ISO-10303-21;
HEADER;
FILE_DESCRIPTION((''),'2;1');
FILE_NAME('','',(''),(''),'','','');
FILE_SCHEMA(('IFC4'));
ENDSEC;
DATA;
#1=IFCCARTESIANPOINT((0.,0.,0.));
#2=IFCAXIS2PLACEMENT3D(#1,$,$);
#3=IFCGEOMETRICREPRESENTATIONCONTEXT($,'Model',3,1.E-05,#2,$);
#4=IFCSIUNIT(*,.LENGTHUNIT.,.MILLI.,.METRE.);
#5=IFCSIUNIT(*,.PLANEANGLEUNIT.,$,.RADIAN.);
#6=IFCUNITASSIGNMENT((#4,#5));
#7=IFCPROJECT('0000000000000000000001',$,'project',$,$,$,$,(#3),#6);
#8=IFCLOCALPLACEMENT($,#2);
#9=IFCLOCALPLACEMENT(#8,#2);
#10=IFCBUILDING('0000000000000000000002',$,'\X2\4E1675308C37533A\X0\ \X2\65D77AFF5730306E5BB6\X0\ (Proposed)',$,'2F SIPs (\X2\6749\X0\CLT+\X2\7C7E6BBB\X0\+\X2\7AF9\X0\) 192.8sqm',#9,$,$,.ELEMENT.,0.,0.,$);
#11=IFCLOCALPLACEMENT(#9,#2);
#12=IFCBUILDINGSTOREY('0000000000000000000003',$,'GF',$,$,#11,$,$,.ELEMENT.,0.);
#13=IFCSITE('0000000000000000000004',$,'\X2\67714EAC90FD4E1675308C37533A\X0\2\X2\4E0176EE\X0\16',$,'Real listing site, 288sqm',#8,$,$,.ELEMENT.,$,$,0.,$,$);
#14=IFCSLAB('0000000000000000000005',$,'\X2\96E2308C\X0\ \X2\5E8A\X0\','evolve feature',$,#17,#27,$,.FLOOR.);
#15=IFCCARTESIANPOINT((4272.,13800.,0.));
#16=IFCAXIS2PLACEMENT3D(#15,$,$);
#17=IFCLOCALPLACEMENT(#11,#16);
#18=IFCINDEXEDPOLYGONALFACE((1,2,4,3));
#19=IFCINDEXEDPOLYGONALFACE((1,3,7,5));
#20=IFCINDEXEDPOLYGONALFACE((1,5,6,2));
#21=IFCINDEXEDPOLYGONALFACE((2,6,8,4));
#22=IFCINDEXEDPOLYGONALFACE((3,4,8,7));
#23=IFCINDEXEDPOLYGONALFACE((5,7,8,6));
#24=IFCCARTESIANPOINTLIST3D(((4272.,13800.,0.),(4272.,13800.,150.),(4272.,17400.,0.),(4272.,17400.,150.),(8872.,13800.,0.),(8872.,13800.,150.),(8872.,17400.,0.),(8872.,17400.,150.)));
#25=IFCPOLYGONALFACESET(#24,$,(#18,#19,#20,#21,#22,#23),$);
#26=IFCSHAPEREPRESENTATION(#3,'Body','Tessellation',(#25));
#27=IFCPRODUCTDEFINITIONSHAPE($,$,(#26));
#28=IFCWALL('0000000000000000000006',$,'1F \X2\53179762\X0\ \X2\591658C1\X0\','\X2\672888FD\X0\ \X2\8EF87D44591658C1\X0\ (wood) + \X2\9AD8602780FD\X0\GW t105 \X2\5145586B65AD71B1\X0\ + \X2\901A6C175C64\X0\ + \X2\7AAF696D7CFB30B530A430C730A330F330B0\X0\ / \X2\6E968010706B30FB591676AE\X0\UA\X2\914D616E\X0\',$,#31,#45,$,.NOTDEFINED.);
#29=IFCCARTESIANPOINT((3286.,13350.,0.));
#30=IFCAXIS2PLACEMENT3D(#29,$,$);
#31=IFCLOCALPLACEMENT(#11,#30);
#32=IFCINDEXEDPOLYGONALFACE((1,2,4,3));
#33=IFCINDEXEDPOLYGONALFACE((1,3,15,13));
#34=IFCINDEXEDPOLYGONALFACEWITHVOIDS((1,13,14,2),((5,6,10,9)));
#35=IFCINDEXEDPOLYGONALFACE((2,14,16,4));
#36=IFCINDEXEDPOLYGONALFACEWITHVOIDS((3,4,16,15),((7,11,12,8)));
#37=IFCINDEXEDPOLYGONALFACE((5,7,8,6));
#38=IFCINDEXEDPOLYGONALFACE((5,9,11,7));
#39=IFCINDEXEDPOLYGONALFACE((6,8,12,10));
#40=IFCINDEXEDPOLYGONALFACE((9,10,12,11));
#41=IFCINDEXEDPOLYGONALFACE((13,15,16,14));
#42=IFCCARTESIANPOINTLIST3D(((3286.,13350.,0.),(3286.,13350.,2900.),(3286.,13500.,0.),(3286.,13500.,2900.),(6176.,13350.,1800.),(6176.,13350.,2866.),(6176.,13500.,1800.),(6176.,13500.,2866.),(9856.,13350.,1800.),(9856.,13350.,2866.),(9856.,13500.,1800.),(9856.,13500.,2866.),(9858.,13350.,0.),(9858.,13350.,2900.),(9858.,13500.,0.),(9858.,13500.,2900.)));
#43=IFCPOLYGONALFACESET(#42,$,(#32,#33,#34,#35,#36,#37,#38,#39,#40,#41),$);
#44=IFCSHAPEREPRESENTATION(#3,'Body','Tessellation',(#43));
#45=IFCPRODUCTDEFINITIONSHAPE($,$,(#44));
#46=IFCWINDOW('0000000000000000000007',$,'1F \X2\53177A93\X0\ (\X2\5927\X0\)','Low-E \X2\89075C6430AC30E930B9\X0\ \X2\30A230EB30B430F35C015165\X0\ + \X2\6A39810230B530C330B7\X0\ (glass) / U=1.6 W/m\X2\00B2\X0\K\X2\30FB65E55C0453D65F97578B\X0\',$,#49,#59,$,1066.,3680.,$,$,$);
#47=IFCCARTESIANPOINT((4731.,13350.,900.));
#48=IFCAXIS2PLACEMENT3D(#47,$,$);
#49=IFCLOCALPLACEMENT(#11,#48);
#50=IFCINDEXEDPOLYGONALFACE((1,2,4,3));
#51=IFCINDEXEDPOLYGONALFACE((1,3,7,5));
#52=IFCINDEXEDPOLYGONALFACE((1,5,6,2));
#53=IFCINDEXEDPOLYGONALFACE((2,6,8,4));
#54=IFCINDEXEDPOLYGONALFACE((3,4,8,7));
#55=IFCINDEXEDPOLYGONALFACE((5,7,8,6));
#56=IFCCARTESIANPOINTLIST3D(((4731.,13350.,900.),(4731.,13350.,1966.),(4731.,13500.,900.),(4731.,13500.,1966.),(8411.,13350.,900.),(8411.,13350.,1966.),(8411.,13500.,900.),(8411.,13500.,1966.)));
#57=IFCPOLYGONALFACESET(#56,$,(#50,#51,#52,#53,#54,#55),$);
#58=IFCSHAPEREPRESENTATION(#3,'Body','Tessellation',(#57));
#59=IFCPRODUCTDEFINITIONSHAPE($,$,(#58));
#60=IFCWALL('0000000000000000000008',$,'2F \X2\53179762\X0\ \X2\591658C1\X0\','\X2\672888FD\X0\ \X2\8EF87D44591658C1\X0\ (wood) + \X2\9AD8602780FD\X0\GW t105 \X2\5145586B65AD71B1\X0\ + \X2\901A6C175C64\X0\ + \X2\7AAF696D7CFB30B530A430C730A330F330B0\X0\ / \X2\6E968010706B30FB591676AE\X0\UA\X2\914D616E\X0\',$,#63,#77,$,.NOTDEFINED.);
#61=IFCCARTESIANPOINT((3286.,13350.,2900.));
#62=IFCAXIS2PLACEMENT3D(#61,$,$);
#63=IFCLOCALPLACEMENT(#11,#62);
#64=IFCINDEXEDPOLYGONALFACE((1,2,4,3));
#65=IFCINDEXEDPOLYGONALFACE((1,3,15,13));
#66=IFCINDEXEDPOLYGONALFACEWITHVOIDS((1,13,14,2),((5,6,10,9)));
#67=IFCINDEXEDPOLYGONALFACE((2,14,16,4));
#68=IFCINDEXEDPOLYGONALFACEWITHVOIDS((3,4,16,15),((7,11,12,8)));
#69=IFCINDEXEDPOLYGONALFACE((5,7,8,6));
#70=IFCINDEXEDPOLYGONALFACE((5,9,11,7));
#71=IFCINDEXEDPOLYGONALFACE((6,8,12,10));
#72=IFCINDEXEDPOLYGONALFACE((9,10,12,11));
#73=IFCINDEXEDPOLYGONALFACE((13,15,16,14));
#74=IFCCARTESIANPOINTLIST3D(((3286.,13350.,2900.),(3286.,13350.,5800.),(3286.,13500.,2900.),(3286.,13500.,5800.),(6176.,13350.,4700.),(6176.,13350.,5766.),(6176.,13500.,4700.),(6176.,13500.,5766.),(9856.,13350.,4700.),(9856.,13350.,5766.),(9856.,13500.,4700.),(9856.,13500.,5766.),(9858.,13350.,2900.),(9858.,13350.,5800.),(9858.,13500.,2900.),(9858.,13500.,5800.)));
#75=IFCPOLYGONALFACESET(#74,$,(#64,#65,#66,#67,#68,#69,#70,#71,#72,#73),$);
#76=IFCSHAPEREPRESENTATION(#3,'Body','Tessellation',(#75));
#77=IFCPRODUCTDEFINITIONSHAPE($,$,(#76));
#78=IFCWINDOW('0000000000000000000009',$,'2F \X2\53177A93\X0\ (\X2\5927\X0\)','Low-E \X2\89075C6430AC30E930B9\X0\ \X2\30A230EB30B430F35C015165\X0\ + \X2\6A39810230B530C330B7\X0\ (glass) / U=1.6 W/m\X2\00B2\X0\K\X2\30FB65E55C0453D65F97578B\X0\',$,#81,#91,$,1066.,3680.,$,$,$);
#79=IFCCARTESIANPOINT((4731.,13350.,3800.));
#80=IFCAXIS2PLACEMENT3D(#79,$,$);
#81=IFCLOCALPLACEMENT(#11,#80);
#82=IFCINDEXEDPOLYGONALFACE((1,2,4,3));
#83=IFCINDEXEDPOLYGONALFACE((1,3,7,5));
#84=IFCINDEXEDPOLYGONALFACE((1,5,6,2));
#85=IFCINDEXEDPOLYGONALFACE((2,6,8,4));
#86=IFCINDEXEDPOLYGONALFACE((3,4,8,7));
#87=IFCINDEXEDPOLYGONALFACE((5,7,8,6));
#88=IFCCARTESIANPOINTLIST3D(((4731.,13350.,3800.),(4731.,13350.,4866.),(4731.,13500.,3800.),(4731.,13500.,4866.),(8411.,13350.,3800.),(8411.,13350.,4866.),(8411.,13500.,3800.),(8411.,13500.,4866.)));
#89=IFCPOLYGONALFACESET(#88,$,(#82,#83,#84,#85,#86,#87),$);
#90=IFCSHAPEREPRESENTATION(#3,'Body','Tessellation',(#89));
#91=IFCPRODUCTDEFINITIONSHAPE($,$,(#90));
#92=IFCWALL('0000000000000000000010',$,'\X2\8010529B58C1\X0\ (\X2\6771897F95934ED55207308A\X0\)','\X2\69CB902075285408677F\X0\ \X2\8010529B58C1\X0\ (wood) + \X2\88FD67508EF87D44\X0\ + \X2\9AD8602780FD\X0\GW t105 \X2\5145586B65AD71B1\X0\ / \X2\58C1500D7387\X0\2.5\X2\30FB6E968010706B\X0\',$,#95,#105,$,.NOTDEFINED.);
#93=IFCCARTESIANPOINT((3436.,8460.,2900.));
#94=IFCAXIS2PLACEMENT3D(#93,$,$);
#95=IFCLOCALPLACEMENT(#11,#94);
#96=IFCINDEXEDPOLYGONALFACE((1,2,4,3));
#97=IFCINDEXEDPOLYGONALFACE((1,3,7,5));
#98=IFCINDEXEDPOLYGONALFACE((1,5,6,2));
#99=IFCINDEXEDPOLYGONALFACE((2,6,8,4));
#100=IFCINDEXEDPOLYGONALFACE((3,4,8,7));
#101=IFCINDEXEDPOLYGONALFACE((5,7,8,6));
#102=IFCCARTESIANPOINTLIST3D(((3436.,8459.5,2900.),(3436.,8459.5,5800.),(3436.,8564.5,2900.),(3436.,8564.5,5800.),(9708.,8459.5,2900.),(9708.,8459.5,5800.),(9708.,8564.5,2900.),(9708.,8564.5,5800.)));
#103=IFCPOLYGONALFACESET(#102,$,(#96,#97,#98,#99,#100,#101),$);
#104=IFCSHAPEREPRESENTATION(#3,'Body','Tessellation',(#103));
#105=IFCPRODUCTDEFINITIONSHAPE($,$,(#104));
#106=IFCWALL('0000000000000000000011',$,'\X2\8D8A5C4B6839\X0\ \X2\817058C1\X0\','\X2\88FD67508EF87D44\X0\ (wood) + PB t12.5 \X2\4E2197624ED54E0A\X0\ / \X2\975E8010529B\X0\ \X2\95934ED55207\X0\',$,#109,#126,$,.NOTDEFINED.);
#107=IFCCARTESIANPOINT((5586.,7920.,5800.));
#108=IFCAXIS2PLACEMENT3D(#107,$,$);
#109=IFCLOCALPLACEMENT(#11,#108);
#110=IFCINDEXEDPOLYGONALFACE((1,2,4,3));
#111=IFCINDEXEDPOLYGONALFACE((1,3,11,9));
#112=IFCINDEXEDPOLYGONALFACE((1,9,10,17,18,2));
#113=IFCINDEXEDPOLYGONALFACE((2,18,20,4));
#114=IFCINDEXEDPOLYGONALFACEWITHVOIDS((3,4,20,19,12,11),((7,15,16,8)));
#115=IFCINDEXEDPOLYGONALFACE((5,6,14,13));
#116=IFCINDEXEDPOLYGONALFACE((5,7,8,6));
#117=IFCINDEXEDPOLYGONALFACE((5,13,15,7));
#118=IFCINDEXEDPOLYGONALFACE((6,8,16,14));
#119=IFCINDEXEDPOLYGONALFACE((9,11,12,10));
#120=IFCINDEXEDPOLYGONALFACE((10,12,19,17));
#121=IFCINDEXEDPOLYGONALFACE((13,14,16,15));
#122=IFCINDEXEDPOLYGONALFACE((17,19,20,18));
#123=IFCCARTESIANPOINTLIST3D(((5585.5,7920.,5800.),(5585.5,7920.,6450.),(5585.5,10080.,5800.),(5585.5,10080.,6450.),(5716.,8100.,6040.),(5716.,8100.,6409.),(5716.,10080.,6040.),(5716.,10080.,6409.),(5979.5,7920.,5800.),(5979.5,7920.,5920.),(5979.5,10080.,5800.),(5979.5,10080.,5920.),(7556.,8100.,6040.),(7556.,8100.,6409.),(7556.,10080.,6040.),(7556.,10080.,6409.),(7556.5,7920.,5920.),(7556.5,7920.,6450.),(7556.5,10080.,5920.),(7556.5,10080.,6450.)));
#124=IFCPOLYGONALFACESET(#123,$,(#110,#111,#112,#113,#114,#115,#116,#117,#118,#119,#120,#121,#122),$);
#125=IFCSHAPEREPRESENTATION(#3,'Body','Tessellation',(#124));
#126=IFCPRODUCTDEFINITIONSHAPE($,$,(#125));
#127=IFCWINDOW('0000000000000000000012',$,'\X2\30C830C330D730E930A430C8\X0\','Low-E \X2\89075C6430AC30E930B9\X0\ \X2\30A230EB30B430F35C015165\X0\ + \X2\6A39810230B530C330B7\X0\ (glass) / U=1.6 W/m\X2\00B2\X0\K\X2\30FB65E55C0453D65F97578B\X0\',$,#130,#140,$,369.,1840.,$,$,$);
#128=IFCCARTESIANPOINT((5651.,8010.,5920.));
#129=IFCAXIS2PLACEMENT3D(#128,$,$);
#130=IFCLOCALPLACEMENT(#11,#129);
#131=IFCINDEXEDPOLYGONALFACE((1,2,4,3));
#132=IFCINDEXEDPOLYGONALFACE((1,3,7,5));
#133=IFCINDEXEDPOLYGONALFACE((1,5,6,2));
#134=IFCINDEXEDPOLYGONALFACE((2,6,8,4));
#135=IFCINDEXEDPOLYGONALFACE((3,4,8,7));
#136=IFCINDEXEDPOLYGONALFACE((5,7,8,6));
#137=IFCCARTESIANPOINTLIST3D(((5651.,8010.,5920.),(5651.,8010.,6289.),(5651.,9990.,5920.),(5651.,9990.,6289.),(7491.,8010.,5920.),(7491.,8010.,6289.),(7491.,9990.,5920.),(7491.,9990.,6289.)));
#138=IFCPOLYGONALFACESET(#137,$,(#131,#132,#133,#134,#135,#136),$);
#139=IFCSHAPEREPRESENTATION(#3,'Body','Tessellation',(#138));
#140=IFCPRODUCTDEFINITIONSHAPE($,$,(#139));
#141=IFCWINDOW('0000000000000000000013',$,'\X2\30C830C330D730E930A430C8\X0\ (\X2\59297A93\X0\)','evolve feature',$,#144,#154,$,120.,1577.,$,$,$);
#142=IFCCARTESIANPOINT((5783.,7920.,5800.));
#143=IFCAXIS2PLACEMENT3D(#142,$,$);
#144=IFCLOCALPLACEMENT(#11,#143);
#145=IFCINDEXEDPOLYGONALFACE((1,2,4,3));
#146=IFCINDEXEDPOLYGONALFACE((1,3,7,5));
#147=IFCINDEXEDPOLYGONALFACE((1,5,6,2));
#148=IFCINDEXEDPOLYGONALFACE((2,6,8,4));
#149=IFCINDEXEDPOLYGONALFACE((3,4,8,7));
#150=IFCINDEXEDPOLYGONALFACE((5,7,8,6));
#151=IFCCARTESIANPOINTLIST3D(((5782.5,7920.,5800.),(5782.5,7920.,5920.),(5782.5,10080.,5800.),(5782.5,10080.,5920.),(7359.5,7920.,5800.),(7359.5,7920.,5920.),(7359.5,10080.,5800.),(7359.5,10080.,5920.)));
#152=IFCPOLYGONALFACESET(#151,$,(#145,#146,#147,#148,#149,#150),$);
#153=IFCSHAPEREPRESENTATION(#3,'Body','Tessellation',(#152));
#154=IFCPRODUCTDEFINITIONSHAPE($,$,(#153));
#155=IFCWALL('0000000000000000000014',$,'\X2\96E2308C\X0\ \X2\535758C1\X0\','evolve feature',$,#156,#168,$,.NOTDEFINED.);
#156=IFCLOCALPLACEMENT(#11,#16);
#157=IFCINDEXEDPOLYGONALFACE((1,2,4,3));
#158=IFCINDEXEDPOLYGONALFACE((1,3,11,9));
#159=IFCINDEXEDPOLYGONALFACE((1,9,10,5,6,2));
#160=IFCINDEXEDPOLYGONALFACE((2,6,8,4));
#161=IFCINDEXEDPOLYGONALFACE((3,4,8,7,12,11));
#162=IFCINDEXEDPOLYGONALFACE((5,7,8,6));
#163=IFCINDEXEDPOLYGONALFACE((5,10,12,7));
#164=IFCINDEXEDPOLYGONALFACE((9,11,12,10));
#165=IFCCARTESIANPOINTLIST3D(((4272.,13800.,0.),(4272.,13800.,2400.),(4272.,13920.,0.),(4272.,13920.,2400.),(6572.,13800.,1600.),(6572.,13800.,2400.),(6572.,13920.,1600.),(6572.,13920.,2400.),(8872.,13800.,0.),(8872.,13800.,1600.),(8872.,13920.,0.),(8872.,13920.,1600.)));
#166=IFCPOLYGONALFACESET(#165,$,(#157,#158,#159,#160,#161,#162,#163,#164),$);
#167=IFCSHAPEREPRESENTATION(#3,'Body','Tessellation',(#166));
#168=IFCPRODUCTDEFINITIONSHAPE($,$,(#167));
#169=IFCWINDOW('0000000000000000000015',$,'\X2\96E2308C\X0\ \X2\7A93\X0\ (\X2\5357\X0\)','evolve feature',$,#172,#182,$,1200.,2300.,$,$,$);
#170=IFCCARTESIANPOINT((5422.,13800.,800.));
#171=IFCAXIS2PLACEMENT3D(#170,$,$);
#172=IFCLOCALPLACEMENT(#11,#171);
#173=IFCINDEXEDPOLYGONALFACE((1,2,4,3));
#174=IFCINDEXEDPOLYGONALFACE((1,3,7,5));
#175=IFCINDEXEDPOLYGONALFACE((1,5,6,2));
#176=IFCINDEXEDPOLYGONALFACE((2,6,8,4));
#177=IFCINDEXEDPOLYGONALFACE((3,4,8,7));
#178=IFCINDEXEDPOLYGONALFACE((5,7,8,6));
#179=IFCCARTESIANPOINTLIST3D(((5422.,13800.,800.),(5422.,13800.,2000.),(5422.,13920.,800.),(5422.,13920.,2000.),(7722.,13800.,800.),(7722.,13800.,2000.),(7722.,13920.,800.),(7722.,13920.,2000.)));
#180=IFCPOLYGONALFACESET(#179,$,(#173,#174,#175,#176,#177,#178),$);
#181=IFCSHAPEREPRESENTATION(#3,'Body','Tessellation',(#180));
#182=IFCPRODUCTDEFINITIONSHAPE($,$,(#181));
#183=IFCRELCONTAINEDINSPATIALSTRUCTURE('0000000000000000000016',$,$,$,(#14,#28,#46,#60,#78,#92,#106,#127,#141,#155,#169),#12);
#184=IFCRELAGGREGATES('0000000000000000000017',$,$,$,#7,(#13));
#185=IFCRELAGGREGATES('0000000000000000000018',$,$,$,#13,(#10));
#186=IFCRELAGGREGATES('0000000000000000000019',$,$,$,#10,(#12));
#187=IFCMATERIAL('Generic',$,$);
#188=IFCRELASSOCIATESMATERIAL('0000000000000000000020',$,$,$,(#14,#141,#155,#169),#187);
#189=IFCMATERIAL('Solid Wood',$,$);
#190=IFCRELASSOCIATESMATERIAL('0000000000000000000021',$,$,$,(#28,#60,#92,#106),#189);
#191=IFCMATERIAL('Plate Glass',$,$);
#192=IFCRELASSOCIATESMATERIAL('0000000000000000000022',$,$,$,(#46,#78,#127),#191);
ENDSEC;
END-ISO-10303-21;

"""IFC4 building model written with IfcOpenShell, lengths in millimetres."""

from ifc_helpers import new_model, si_unit, frame, frame_2d, origin, place, context, project, spatial, rectangle, extrude, material, element, fill, save


model = new_model("IFC4")

# Units and contexts
model_context = context("Model", 3, precision=1e-05, world=origin())
ifc_project = project(units=[si_unit("LENGTHUNIT", "METRE", prefix="MILLI"), si_unit("PLANEANGLEUNIT", "RADIAN")], contexts=[model_context])

# Site, building, storey
site_placement = place(None, origin())
site = spatial("IfcSite", under=ifc_project, at=site_placement, Name="東京都世田谷区2丁目16", ObjectType="Real listing site, 288sqm", CompositionType="ELEMENT", RefElevation=0.0)
building_placement = place(site_placement, origin())
building = spatial("IfcBuilding", under=site, at=building_placement, Name="世田谷区 旗竿地の家 (Proposed)", ObjectType="2F SIPs (杉CLT+籾殻+竹) 192.8sqm", CompositionType="ELEMENT", ElevationOfRefHeight=0.0, ElevationOfTerrain=0.0)
storey_placement = place(building_placement, origin())
storey = spatial("IfcBuildingStorey", under=building, at=storey_placement, Name="GF", CompositionType="ELEMENT", Elevation=0.0)

# Slab
ifc_material_1 = material(Name="Generic")
slab_placement = place(storey_placement, frame((4272.0, 13800.0, 0.0)))
element("IfcSlab", 1, at=slab_placement, inside=storey, material=ifc_material_1, Name="離れ 床", Description="evolve feature", PredefinedType="FLOOR", context=model_context, shape_type="SweptSolid", body=[
    extrude(rectangle(XDim=4600.0, YDim=3600.0, at=frame_2d((2300.0, 1800.0))), frame((4272.0, 13800.0, 0.0)), (0.0, 0.0, 1.0), 150.0),
])

# Wall, opening, window
ifc_material_2 = material(Name="Solid Wood")
wall_1_placement = place(storey_placement, frame((3286.0, 13350.0, 0.0)))
wall_1 = element("IfcWall", 2, at=wall_1_placement, inside=storey, material=ifc_material_2, Name="1F 北面 外壁", Description="木製 軸組外壁 (wood) + 高性能GW t105 充填断熱 + 通気層 + 窯業系サイディング / 準耐火・外皮UA配慮", PredefinedType="NOTDEFINED", context=model_context, shape_type="SweptSolid", body=[
    extrude(rectangle(XDim=6572.0, YDim=150.0, at=frame_2d((3286.0, 75.0))), frame((3286.0, 13350.0, 0.0)), (0.0, 0.0, 1.0), 2900.0),
])
opening_1_placement = place(storey_placement, frame((4731.0, 13350.0, 900.0)))
opening_1 = element("IfcOpeningElement", 3, at=opening_1_placement, cuts=wall_1, PredefinedType="NOTDEFINED", context=model_context, shape_type="SweptSolid", body=[
    extrude(rectangle(XDim=3680.0, YDim=150.0, at=frame_2d((1840.0, 75.0))), frame((4731.0, 13350.0, 900.0)), (0.0, 0.0, 1.0), 1066.0),
])
ifc_material_3 = material(Name="Plate Glass")
window_1_placement = place(storey_placement, frame((4731.0, 13350.0, 900.0)))
window_1 = element("IfcWindow", 4, at=window_1_placement, inside=storey, material=ifc_material_3, Name="1F 北窓 (大)", Description="Low-E 複層ガラス アルゴン封入 + 樹脂サッシ (glass) / U=1.6 W/m²K・日射取得型", OverallHeight=1066.0, OverallWidth=3680.0, context=model_context, shape_type="SweptSolid", body=[
    extrude(rectangle(XDim=3680.0, YDim=150.0, at=frame_2d((1840.0, 75.0))), frame((4731.0, 13350.0, 900.0)), (0.0, 0.0, 1.0), 1066.0),
])
fill(opening_1, window_1)

# Wall, opening, window
wall_2_placement = place(storey_placement, frame((3286.0, 13350.0, 2900.0)))
wall_2 = element("IfcWall", 5, at=wall_2_placement, inside=storey, material=ifc_material_2, Name="2F 北面 外壁", Description="木製 軸組外壁 (wood) + 高性能GW t105 充填断熱 + 通気層 + 窯業系サイディング / 準耐火・外皮UA配慮", PredefinedType="NOTDEFINED", context=model_context, shape_type="SweptSolid", body=[
    extrude(rectangle(XDim=6572.0, YDim=150.0, at=frame_2d((3286.0, 75.0))), frame((3286.0, 13350.0, 2900.0)), (0.0, 0.0, 1.0), 2900.0),
])
opening_2_placement = place(storey_placement, frame((4731.0, 13350.0, 3800.0)))
opening_2 = element("IfcOpeningElement", 6, at=opening_2_placement, cuts=wall_2, PredefinedType="NOTDEFINED", context=model_context, shape_type="SweptSolid", body=[
    extrude(rectangle(XDim=3680.0, YDim=150.0, at=frame_2d((1840.0, 75.0))), frame((4731.0, 13350.0, 3800.0)), (0.0, 0.0, 1.0), 1066.0),
])
window_2_placement = place(storey_placement, frame((4731.0, 13350.0, 3800.0)))
window_2 = element("IfcWindow", 7, at=window_2_placement, inside=storey, material=ifc_material_3, Name="2F 北窓 (大)", Description="Low-E 複層ガラス アルゴン封入 + 樹脂サッシ (glass) / U=1.6 W/m²K・日射取得型", OverallHeight=1066.0, OverallWidth=3680.0, context=model_context, shape_type="SweptSolid", body=[
    extrude(rectangle(XDim=3680.0, YDim=150.0, at=frame_2d((1840.0, 75.0))), frame((4731.0, 13350.0, 3800.0)), (0.0, 0.0, 1.0), 1066.0),
])
fill(opening_2, window_2)

# Wall
wall_3_placement = place(storey_placement, frame((3436.0, 8460.0, 2900.0)))
element("IfcWall", 8, at=wall_3_placement, inside=storey, material=ifc_material_2, Name="耐力壁 (東西間仕切り)", Description="構造用合板 耐力壁 (wood) + 製材軸組 + 高性能GW t105 充填断熱 / 壁倍率2.5・準耐火", PredefinedType="NOTDEFINED", context=model_context, shape_type="SweptSolid", body=[
    extrude(rectangle(XDim=6272.0, YDim=105.0, at=frame_2d((3136.0, 52.0))), frame((3436.0, 8460.0, 2900.0)), (0.0, 0.0, 1.0), 2900.0),
])

# Wall, openings, windows
wall_4_placement = place(storey_placement, frame((5586.0, 7920.0, 5800.0)))
wall_4 = element("IfcWall", 9, at=wall_4_placement, inside=storey, material=ifc_material_2, Name="越屋根 腰壁", Description="製材軸組 (wood) + PB t12.5 両面仕上 / 非耐力 間仕切", PredefinedType="NOTDEFINED", context=model_context, shape_type="SweptSolid", body=[
    extrude(rectangle(XDim=1971.0, YDim=2160.0, at=frame_2d((985.0, 1080.0))), frame((5586.0, 7920.0, 5800.0)), (0.0, 0.0, 1.0), 650.0),
])
opening_3_placement = place(storey_placement, frame((5651.0, 8010.0, 5920.0)))
opening_3 = element("IfcOpeningElement", 10, at=opening_3_placement, cuts=wall_4, PredefinedType="NOTDEFINED", context=model_context, shape_type="SweptSolid", body=[
    extrude(rectangle(XDim=1840.0, YDim=1980.0, at=frame_2d((920.0, 990.0))), frame((5651.0, 8010.0, 5920.0)), (0.0, 0.0, 1.0), 369.0),
])
opening_4_placement = place(storey_placement, frame((5783.0, 7920.0, 5800.0)))
opening_4 = element("IfcOpeningElement", 11, at=opening_4_placement, cuts=wall_4, PredefinedType="NOTDEFINED", context=model_context, shape_type="SweptSolid", body=[
    extrude(rectangle(XDim=1577.0, YDim=2160.0, at=frame_2d((788.0, 1080.0))), frame((5783.0, 7920.0, 5800.0)), (0.0, 0.0, 1.0), 120.0),
])
window_3_placement = place(storey_placement, frame((5651.0, 8010.0, 5920.0)))
window_3 = element("IfcWindow", 12, at=window_3_placement, inside=storey, material=ifc_material_3, Name="トップライト", Description="Low-E 複層ガラス アルゴン封入 + 樹脂サッシ (glass) / U=1.6 W/m²K・日射取得型", OverallHeight=369.0, OverallWidth=1840.0, context=model_context, shape_type="SweptSolid", body=[
    extrude(rectangle(XDim=1840.0, YDim=1980.0, at=frame_2d((920.0, 990.0))), frame((5651.0, 8010.0, 5920.0)), (0.0, 0.0, 1.0), 369.0),
])
fill(opening_3, window_3)
window_4_placement = place(storey_placement, frame((5783.0, 7920.0, 5800.0)))
window_4 = element("IfcWindow", 13, at=window_4_placement, inside=storey, material=ifc_material_1, Name="トップライト (天窓)", Description="evolve feature", OverallHeight=120.0, OverallWidth=1577.0, context=model_context, shape_type="SweptSolid", body=[
    extrude(rectangle(XDim=1577.0, YDim=2160.0, at=frame_2d((788.0, 1080.0))), frame((5783.0, 7920.0, 5800.0)), (0.0, 0.0, 1.0), 120.0),
])
fill(opening_4, window_4)

# Wall, opening, window
wall_5_placement = place(storey_placement, frame((4272.0, 13800.0, 0.0)))
wall_5 = element("IfcWall", 14, at=wall_5_placement, inside=storey, material=ifc_material_1, Name="離れ 南壁", Description="evolve feature", PredefinedType="NOTDEFINED", context=model_context, shape_type="SweptSolid", body=[
    extrude(rectangle(XDim=4600.0, YDim=120.0, at=frame_2d((2300.0, 60.0))), frame((4272.0, 13800.0, 0.0)), (0.0, 0.0, 1.0), 2400.0),
])
opening_5_placement = place(storey_placement, frame((5422.0, 13800.0, 800.0)))
opening_5 = element("IfcOpeningElement", 15, at=opening_5_placement, cuts=wall_5, PredefinedType="NOTDEFINED", context=model_context, shape_type="SweptSolid", body=[
    extrude(rectangle(XDim=2300.0, YDim=120.0, at=frame_2d((1150.0, 60.0))), frame((5422.0, 13800.0, 800.0)), (0.0, 0.0, 1.0), 1200.0),
])
window_5_placement = place(storey_placement, frame((5422.0, 13800.0, 800.0)))
window_5 = element("IfcWindow", 16, at=window_5_placement, inside=storey, material=ifc_material_1, Name="離れ 窓 (南)", Description="evolve feature", OverallHeight=1200.0, OverallWidth=2300.0, context=model_context, shape_type="SweptSolid", body=[
    extrude(rectangle(XDim=2300.0, YDim=120.0, at=frame_2d((1150.0, 60.0))), frame((5422.0, 13800.0, 800.0)), (0.0, 0.0, 1.0), 1200.0),
])
fill(opening_5, window_5)

save(model, "model.ifc")
